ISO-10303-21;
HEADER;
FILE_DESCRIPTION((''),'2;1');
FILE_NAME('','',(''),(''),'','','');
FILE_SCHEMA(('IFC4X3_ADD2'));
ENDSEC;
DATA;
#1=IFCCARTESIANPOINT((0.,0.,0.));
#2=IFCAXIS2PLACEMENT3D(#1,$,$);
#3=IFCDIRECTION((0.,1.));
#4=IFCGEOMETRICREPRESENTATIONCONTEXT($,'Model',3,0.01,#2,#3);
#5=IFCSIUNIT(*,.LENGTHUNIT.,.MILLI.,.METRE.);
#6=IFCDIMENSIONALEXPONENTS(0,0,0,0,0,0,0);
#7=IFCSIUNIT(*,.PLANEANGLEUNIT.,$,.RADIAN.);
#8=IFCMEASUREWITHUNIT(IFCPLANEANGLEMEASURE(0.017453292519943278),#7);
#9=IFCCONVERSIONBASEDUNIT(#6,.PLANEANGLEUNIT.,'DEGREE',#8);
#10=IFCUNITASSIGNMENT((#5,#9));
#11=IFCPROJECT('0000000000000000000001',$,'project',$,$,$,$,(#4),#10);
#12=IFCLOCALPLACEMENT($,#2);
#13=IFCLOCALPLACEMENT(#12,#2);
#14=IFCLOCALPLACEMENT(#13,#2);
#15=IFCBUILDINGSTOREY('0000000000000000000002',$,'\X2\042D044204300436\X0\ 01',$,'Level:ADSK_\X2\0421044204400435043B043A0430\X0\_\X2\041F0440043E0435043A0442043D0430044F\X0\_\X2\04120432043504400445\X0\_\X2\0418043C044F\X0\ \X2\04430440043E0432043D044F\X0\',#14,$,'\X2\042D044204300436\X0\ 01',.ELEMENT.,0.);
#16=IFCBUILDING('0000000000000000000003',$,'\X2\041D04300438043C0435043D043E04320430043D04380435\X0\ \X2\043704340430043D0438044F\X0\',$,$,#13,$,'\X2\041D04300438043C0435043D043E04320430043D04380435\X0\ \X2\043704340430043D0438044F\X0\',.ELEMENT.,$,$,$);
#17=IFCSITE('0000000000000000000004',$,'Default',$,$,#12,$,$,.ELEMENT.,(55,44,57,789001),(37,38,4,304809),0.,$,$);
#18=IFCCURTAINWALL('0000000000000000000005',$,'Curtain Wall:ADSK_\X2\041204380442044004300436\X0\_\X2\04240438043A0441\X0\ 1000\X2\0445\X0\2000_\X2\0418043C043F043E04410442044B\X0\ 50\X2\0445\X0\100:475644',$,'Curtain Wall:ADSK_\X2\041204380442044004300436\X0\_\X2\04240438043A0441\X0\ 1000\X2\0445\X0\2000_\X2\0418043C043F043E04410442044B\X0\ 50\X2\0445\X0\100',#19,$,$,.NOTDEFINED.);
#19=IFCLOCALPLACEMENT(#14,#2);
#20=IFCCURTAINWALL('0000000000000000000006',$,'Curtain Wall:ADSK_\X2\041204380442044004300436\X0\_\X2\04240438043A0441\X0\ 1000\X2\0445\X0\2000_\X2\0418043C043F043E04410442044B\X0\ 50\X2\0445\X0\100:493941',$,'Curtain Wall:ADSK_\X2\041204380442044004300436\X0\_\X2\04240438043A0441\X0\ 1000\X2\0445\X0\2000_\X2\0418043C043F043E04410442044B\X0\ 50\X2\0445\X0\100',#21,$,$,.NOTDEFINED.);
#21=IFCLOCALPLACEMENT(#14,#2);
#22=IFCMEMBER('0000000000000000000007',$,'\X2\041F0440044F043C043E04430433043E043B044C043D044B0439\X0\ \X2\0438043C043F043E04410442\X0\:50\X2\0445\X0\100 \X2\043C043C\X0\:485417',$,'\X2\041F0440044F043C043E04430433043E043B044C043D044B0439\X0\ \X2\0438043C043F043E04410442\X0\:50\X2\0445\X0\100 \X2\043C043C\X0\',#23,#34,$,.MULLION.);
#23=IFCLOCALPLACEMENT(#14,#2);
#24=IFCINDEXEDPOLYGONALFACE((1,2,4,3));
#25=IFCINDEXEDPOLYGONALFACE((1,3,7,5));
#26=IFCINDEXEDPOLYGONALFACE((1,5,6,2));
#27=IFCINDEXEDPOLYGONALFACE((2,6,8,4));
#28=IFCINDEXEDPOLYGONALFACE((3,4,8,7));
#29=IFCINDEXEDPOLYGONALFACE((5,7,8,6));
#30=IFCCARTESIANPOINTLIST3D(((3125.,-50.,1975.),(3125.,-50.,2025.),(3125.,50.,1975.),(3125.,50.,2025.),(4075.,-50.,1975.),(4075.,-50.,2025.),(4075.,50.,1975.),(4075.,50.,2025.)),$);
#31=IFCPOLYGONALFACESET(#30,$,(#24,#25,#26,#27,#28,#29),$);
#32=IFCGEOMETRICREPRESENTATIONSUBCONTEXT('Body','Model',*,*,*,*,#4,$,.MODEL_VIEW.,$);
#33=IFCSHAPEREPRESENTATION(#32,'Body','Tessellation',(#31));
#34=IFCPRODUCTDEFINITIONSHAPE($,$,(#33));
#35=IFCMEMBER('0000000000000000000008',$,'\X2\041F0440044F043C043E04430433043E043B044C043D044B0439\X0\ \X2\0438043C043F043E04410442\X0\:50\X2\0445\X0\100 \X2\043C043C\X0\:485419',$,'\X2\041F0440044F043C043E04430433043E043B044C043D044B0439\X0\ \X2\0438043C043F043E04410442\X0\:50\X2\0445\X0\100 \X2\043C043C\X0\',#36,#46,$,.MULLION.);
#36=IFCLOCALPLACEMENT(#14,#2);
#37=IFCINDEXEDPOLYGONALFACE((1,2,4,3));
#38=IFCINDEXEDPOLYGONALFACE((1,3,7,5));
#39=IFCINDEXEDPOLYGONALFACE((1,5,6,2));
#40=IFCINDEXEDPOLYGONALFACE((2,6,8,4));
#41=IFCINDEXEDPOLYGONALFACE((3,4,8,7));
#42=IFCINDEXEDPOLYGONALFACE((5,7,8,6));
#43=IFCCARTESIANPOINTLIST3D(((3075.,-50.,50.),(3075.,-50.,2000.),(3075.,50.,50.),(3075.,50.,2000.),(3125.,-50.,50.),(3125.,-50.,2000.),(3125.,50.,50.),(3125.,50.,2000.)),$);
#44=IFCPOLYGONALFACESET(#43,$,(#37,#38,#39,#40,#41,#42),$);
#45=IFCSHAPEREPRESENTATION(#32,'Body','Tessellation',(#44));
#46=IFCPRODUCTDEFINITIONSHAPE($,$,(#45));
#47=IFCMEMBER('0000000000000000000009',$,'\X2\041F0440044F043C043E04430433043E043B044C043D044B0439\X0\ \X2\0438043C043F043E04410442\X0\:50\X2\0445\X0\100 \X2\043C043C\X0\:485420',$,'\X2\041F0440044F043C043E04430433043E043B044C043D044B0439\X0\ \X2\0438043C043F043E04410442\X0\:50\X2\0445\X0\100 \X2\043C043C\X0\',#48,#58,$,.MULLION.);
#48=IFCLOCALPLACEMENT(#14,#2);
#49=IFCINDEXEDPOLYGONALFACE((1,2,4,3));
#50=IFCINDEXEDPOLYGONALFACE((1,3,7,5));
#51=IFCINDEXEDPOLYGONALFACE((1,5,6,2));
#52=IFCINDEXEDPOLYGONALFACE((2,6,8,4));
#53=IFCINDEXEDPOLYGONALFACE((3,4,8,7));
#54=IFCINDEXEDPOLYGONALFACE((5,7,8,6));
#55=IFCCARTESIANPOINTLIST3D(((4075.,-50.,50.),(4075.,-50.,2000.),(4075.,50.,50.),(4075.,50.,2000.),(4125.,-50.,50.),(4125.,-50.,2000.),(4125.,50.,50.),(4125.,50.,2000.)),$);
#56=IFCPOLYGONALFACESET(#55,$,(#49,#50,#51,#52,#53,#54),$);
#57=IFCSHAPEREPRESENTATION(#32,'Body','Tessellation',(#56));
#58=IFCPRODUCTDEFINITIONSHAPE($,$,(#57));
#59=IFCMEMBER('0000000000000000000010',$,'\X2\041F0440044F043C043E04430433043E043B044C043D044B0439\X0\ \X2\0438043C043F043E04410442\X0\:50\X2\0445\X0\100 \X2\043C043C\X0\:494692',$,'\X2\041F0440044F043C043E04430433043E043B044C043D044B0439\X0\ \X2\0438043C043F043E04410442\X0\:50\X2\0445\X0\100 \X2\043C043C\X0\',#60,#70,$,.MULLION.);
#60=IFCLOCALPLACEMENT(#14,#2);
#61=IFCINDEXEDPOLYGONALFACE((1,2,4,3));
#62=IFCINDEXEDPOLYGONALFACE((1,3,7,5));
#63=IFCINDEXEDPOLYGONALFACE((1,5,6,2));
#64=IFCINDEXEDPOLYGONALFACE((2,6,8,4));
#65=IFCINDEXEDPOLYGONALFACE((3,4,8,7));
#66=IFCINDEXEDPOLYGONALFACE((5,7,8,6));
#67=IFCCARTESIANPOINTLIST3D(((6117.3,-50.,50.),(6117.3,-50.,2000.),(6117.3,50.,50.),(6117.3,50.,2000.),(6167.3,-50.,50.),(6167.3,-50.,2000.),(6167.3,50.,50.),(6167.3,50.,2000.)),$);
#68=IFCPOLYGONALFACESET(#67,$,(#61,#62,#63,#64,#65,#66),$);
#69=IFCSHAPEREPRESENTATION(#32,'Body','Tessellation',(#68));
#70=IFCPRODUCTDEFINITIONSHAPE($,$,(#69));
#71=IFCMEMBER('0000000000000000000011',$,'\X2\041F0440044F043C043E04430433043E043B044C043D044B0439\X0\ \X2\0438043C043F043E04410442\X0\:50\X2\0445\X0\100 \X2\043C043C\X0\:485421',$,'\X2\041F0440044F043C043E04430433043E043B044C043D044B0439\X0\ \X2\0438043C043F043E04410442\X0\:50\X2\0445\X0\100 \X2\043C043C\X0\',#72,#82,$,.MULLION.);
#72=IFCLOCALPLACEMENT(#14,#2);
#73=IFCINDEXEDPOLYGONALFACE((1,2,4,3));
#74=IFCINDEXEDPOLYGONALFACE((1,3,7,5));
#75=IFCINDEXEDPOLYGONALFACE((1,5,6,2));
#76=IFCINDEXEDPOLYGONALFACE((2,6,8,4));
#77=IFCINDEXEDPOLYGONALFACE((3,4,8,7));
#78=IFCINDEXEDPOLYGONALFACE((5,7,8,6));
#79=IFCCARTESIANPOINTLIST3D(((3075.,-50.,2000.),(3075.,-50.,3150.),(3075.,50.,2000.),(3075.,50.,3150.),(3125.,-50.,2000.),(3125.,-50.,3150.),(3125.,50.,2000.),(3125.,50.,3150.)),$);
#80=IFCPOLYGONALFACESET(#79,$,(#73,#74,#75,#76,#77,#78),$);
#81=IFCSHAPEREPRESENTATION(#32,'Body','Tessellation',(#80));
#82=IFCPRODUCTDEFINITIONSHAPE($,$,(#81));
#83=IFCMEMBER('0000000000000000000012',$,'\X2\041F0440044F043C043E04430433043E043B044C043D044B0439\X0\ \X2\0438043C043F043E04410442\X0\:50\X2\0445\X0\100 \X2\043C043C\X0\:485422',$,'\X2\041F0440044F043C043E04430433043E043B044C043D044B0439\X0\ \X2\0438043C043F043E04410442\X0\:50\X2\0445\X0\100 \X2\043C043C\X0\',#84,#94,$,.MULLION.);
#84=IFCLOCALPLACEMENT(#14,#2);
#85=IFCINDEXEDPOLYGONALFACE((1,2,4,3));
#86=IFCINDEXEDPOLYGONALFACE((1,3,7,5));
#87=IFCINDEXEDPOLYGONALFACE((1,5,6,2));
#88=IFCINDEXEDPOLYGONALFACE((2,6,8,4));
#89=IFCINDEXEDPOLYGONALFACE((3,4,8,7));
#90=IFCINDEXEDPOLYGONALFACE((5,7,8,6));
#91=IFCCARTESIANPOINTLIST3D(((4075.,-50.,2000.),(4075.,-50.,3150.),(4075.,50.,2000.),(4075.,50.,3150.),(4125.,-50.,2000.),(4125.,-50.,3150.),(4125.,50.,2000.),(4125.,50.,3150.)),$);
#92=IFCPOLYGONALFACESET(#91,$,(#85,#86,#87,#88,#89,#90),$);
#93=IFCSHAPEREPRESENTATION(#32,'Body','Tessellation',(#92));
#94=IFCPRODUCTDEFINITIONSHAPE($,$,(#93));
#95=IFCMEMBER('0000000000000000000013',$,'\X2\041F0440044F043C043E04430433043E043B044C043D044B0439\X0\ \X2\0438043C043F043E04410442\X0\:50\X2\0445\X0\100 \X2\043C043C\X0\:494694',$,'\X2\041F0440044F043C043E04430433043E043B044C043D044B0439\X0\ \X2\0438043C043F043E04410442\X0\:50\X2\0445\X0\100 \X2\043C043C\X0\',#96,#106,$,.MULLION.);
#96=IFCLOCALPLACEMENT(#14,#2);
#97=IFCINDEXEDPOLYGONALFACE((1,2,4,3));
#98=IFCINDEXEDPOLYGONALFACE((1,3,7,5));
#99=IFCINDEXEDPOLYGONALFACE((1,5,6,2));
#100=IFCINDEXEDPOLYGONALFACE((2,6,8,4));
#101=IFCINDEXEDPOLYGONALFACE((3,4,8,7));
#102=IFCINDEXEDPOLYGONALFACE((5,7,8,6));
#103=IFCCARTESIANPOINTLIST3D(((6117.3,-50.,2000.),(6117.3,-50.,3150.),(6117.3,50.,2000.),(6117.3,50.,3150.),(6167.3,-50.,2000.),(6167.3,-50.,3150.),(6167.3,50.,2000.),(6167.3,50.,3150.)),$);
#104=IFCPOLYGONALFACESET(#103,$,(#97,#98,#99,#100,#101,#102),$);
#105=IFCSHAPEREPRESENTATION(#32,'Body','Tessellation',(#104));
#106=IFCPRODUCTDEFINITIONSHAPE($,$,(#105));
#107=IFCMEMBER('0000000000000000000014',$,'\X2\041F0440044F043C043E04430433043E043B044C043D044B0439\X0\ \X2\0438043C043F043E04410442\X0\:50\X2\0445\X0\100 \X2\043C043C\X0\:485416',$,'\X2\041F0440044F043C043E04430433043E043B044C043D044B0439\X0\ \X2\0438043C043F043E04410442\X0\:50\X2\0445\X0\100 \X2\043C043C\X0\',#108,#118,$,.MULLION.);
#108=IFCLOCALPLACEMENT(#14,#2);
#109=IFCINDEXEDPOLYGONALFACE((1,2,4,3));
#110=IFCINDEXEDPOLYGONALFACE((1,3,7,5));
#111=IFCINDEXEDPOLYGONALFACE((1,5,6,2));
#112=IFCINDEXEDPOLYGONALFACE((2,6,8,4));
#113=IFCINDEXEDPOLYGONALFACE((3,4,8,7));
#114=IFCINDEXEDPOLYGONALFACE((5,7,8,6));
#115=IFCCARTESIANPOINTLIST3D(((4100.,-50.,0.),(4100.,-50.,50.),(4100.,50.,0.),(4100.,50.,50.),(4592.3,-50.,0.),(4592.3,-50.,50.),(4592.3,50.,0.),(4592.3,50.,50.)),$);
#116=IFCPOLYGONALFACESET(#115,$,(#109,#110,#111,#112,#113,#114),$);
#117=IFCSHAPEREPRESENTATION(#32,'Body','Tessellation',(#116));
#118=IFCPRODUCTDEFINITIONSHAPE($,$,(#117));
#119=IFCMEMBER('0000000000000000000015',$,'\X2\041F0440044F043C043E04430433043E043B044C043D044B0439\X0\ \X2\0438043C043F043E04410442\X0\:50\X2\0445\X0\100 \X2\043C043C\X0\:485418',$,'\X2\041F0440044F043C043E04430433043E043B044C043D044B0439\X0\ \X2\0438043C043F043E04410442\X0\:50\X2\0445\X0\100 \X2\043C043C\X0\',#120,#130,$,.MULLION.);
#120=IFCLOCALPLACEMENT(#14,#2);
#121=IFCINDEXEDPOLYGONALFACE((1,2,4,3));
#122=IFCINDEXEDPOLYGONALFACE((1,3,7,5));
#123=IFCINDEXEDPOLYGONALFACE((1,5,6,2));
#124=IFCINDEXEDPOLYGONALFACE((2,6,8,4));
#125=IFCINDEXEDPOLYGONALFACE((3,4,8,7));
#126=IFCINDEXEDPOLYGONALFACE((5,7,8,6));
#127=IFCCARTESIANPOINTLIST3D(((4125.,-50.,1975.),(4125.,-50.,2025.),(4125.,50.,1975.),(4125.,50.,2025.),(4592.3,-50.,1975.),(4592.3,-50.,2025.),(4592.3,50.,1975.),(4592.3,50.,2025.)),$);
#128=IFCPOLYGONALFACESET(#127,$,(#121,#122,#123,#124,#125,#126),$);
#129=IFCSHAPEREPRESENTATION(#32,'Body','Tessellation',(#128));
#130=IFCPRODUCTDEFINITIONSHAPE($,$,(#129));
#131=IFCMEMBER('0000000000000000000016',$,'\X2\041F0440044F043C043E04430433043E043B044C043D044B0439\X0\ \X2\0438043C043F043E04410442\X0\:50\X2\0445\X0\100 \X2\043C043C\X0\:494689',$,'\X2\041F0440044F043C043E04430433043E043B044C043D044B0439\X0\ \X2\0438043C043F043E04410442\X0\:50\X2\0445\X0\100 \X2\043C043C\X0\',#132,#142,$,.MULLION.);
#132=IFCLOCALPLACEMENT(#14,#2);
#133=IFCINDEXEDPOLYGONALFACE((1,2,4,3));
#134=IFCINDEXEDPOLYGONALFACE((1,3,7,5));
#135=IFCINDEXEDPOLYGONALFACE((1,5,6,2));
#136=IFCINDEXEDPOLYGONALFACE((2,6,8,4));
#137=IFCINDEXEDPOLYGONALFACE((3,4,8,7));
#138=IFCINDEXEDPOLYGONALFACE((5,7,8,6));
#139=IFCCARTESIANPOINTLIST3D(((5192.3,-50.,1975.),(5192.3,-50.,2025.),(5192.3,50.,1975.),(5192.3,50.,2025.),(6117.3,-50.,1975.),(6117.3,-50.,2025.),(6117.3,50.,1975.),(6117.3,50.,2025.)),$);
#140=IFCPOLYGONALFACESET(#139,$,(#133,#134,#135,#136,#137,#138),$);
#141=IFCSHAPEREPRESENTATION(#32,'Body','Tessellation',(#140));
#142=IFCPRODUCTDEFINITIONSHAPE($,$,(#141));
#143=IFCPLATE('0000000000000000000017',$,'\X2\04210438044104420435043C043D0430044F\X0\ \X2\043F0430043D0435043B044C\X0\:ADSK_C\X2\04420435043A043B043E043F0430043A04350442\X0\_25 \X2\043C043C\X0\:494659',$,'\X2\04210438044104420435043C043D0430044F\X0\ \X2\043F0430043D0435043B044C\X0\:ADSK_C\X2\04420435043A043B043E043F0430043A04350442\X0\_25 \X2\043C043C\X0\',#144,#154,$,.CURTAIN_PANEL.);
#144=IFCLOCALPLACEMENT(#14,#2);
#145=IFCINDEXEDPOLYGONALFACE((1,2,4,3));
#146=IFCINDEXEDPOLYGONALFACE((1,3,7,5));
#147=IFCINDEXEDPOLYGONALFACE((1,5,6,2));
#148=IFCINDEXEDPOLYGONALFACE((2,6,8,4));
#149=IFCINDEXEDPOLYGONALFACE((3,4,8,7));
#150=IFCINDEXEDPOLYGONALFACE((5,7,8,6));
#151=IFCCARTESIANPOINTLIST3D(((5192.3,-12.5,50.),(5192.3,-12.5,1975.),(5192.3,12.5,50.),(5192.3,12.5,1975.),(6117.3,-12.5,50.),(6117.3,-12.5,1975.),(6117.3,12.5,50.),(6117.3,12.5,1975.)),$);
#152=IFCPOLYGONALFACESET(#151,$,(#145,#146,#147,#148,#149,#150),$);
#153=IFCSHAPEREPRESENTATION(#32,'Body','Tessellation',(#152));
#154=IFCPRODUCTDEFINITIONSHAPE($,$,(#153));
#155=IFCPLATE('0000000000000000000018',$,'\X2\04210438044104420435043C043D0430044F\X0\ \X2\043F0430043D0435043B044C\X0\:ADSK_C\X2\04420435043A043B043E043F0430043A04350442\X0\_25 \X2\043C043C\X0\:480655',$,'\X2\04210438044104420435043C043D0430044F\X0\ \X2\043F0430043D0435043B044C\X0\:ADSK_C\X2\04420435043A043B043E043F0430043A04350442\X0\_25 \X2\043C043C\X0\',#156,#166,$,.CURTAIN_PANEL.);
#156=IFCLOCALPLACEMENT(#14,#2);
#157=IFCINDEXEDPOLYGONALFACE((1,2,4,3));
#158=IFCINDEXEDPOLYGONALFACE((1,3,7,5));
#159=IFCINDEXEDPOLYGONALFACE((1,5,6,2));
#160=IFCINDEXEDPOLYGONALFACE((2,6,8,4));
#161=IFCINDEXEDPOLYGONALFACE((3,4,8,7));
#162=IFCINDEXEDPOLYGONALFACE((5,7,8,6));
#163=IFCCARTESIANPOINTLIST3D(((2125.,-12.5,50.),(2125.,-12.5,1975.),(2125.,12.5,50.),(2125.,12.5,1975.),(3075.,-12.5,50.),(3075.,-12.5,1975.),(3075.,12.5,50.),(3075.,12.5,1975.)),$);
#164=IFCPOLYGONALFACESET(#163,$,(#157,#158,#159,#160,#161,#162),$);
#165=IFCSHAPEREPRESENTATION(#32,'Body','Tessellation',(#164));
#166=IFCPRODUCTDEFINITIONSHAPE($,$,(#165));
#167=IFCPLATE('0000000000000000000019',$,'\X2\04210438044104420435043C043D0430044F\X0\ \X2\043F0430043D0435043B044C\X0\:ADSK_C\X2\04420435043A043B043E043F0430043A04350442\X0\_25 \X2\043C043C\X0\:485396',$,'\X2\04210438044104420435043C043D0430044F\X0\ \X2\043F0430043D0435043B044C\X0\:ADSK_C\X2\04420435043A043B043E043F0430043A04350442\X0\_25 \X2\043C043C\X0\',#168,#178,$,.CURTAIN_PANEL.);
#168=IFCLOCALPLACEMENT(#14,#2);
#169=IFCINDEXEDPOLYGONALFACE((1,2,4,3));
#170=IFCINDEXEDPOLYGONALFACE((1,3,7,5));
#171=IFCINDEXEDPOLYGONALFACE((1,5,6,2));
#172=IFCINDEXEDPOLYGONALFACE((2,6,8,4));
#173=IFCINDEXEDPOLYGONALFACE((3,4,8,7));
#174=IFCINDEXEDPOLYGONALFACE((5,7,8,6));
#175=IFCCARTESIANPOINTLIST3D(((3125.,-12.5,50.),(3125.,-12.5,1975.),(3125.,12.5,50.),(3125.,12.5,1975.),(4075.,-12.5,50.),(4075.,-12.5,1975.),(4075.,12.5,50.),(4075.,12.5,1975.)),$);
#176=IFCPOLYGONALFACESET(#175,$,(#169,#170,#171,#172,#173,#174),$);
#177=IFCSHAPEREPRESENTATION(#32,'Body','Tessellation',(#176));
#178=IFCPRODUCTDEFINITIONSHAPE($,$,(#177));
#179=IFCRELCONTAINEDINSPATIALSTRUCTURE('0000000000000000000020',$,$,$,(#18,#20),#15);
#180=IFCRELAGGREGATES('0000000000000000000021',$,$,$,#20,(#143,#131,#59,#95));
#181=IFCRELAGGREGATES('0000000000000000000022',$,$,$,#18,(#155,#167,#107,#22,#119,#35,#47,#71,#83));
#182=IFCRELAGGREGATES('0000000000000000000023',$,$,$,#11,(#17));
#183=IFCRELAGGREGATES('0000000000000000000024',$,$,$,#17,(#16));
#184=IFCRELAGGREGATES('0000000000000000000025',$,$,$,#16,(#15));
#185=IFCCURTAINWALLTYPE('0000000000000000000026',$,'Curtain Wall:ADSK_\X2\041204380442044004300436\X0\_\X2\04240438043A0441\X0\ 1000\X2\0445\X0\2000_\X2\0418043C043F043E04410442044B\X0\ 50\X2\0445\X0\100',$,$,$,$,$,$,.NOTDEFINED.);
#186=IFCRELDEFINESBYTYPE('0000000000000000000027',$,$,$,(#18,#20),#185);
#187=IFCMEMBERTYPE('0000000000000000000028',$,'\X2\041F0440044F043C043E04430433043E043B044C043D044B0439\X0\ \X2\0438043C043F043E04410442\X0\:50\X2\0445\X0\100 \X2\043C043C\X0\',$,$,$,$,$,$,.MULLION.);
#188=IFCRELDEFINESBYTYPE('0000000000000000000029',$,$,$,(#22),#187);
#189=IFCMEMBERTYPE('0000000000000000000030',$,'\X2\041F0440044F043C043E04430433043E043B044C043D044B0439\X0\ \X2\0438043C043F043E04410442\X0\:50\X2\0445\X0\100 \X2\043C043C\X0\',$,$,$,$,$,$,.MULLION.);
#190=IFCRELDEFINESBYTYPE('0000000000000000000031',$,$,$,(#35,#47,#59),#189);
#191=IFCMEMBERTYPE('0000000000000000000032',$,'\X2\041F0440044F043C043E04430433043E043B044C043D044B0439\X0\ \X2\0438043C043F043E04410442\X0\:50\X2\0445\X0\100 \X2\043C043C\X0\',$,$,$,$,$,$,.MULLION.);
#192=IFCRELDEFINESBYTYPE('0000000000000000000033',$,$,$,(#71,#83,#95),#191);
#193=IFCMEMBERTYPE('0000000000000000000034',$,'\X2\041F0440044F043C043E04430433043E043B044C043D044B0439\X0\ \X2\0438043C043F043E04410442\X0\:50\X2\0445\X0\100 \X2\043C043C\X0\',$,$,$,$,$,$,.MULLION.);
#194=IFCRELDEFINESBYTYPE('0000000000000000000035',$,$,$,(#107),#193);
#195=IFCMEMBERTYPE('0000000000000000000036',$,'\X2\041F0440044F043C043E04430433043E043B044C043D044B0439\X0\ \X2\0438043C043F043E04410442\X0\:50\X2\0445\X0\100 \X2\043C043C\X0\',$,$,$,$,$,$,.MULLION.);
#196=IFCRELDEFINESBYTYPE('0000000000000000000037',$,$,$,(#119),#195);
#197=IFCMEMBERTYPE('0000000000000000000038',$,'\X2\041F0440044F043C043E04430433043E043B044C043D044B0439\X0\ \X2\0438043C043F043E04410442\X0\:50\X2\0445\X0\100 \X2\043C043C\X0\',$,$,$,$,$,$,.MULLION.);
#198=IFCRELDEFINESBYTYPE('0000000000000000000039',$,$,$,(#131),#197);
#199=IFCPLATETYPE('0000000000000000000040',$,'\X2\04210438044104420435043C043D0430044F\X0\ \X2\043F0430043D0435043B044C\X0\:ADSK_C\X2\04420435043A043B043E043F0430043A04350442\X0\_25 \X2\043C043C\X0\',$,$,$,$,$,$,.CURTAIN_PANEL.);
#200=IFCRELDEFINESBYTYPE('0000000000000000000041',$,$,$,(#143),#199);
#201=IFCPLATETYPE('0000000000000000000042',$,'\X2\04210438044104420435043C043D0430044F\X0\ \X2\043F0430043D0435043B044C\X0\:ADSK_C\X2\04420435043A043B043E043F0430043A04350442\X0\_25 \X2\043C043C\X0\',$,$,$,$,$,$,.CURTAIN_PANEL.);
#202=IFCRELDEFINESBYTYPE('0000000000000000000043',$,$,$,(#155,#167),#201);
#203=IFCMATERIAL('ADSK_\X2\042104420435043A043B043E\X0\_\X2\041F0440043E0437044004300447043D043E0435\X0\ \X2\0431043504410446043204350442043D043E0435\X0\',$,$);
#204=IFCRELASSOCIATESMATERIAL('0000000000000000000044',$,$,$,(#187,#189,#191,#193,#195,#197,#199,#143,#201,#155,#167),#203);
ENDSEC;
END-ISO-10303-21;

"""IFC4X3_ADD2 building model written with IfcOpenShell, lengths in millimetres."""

from ifc_helpers import new_model, entity, si_unit, converted_unit, direction, frame, frame_2d, origin, origin_2d_with_axis, place, context, subcontext, project, spatial, rectangle, extrude, source, transform, mapped, material, material_profile, profile_set, type_object, type_shapes, element, aggregate, save


model = new_model("IFC4X3_ADD2")

# Units and contexts
model_context = context("Model", 3, precision=0.01, world=origin(), true_north=direction((0.0, 1.0)))
body_context = subcontext(model_context, "Body", "Model", "MODEL_VIEW")
ifc_project = project(units=[si_unit("LENGTHUNIT", "METRE", prefix="MILLI"), converted_unit("PLANEANGLEUNIT", "DEGREE", entity("IfcPlaneAngleMeasure", 0.017453292519943278), si_unit("PLANEANGLEUNIT", "RADIAN"), dimensions=[0, 0, 0, 0, 0, 0, 0])], contexts=[model_context])

# Site, building, storey
site_placement = place(None, origin())
site = spatial("IfcSite", under=ifc_project, at=site_placement, Name="Default", CompositionType="ELEMENT", RefLatitude=(55, 44, 57, 789001), RefLongitude=(37, 38, 4, 304809), RefElevation=0.0)
building_placement = place(site_placement, origin())
building = spatial("IfcBuilding", under=site, at=building_placement, Name="Наименование здания", LongName="Наименование здания", CompositionType="ELEMENT")
storey_placement = place(building_placement, origin())
storey = spatial("IfcBuildingStorey", under=building, at=storey_placement, Name="Этаж 01", ObjectType="Level:ADSK_Стрелка_Проектная_Вверх_Имя уровня", LongName="Этаж 01", CompositionType="ELEMENT", Elevation=0.0)

# Curtain walls
curtain_wall_type = type_object("IfcCurtainWallType", Name="Curtain Wall:ADSK_Витраж_Фикс 1000х2000_Импосты 50х100", PredefinedType="NOTDEFINED")
curtain_wall_1_placement = place(storey_placement, origin())
curtain_wall_1 = element("IfcCurtainWall", 1, at=curtain_wall_1_placement, inside=storey, type_object=curtain_wall_type, Name="Curtain Wall:ADSK_Витраж_Фикс 1000х2000_Импосты 50х100:475644", ObjectType="Curtain Wall:ADSK_Витраж_Фикс 1000х2000_Импосты 50х100", PredefinedType="NOTDEFINED")
ifc_material_1 = material(Name="ADSK_Стекло_Прозрачное бесцветное")
ifc_material_profile = material_profile(ifc_material_1, rectangle(XDim=50.0, YDim=100.0, at=frame_2d((0.0, 0.0), x_axis=(1.0, 0.0))), Name="50х100 мм")
ifc_profile_set = profile_set([ifc_material_profile], Name="50х100 мм")
curtain_wall_2_placement = place(storey_placement, origin())
curtain_wall_2 = element("IfcCurtainWall", 2, at=curtain_wall_2_placement, inside=storey, type_object=curtain_wall_type, Name="Curtain Wall:ADSK_Витраж_Фикс 1000х2000_Импосты 50х100:493941", ObjectType="Curtain Wall:ADSK_Витраж_Фикс 1000х2000_Импосты 50х100", PredefinedType="NOTDEFINED")

# Members
member_type_1 = type_object("IfcMemberType", Name="Прямоугольный импост:50х100 мм", PredefinedType="MULLION", material=ifc_profile_set)
shared_shape_1 = source(origin(), body_context, "Body", "SweptSolid", [
    extrude(rectangle(XDim=50.0, YDim=100.0, at=frame_2d((0.0, 0.0), x_axis=(1.0, 0.0))), frame((0.0, 0.0, -950.0), z_axis=(0.0, 0.0, 1.0), x_axis=(-1.0, 0.0, 0.0)), (0.0, 0.0, 1.0), 950.0),
])
type_shapes(member_type_1, [shared_shape_1])
member_1_placement = place(curtain_wall_1_placement, frame((4075.0, 0.0, 2000.0), z_axis=(1.0, 0.0, 0.0), x_axis=(0.0, 0.0, 1.0)))
member_1 = element("IfcMember", 3, at=member_1_placement, type_object=member_type_1, Name="Прямоугольный импост:50х100 мм:485417", ObjectType="Прямоугольный импост:50х100 мм", PredefinedType="MULLION", context=body_context, shape_type="MappedRepresentation", body=[
    mapped(shared_shape_1, transform((0.0, 0.0, 0.0), scale=1.0)),
])
member_type_2 = type_object("IfcMemberType", Name="Прямоугольный импост:50х100 мм", PredefinedType="MULLION", material=ifc_profile_set)
shared_shape_2 = source(origin(), body_context, "Body", "SweptSolid", [
    extrude(rectangle(XDim=50.0, YDim=100.0, at=frame_2d((0.0, 0.0), x_axis=(1.0, 0.0))), frame((0.0, 0.0, -1950.0), z_axis=(0.0, 0.0, 1.0), x_axis=(-1.0, 0.0, 0.0)), (0.0, 0.0, 1.0), 1950.0),
])
type_shapes(member_type_2, [shared_shape_2])
member_2_placement = place(curtain_wall_1_placement, frame((3100.0, 0.0, 50.0), z_axis=(0.0, 0.0, -1.0), x_axis=(1.0, 0.0, 0.0)))
member_2 = element("IfcMember", 4, at=member_2_placement, type_object=member_type_2, Name="Прямоугольный импост:50х100 мм:485419", ObjectType="Прямоугольный импост:50х100 мм", PredefinedType="MULLION", context=body_context, shape_type="MappedRepresentation", body=[
    mapped(shared_shape_2, transform((0.0, 0.0, 0.0), scale=1.0)),
])
member_3_placement = place(curtain_wall_1_placement, frame((4100.0, 0.0, 50.0), z_axis=(0.0, 0.0, -1.0), x_axis=(1.0, 0.0, 0.0)))
member_3 = element("IfcMember", 5, at=member_3_placement, type_object=member_type_2, Name="Прямоугольный импост:50х100 мм:485420", ObjectType="Прямоугольный импост:50х100 мм", PredefinedType="MULLION", context=body_context, shape_type="MappedRepresentation", body=[
    mapped(shared_shape_2, transform((0.0, 0.0, 0.0), scale=1.0)),
])
member_4_placement = place(curtain_wall_2_placement, frame((6142.3, 0.0, 50.0), z_axis=(0.0, 0.0, -1.0), x_axis=(1.0, 0.0, 0.0)))
member_4 = element("IfcMember", 6, at=member_4_placement, type_object=member_type_2, Name="Прямоугольный импост:50х100 мм:494692", ObjectType="Прямоугольный импост:50х100 мм", PredefinedType="MULLION", context=body_context, shape_type="MappedRepresentation", body=[
    mapped(shared_shape_2, transform((0.0, 0.0, 0.0), scale=1.0)),
])
member_type_3 = type_object("IfcMemberType", Name="Прямоугольный импост:50х100 мм", PredefinedType="MULLION", material=ifc_profile_set)
shared_shape_3 = source(origin(), body_context, "Body", "SweptSolid", [
    extrude(rectangle(XDim=50.0, YDim=100.0, at=frame_2d((0.0, 0.0), x_axis=(1.0, 0.0))), frame((0.0, 0.0, -1150.0), z_axis=(0.0, 0.0, 1.0), x_axis=(-1.0, 0.0, 0.0)), (0.0, 0.0, 1.0), 1150.0),
])
type_shapes(member_type_3, [shared_shape_3])
member_5_placement = place(curtain_wall_1_placement, frame((3100.0, 0.0, 2000.0), z_axis=(0.0, 0.0, -1.0), x_axis=(1.0, 0.0, 0.0)))
member_5 = element("IfcMember", 7, at=member_5_placement, type_object=member_type_3, Name="Прямоугольный импост:50х100 мм:485421", ObjectType="Прямоугольный импост:50х100 мм", PredefinedType="MULLION", context=body_context, shape_type="MappedRepresentation", body=[
    mapped(shared_shape_3, transform((0.0, 0.0, 0.0), scale=1.0)),
])
member_6_placement = place(curtain_wall_1_placement, frame((4100.0, 0.0, 2000.0), z_axis=(0.0, 0.0, -1.0), x_axis=(1.0, 0.0, 0.0)))
member_6 = element("IfcMember", 8, at=member_6_placement, type_object=member_type_3, Name="Прямоугольный импост:50х100 мм:485422", ObjectType="Прямоугольный импост:50х100 мм", PredefinedType="MULLION", context=body_context, shape_type="MappedRepresentation", body=[
    mapped(shared_shape_3, transform((0.0, 0.0, 0.0), scale=1.0)),
])
member_7_placement = place(curtain_wall_2_placement, frame((6142.3, 0.0, 2000.0), z_axis=(0.0, 0.0, -1.0), x_axis=(1.0, 0.0, 0.0)))
member_7 = element("IfcMember", 9, at=member_7_placement, type_object=member_type_3, Name="Прямоугольный импост:50х100 мм:494694", ObjectType="Прямоугольный импост:50х100 мм", PredefinedType="MULLION", context=body_context, shape_type="MappedRepresentation", body=[
    mapped(shared_shape_3, transform((0.0, 0.0, 0.0), scale=1.0)),
])
member_type_4 = type_object("IfcMemberType", Name="Прямоугольный импост:50х100 мм", PredefinedType="MULLION", material=ifc_profile_set)
shared_shape_4 = source(origin(), body_context, "Body", "SweptSolid", [
    extrude(rectangle(XDim=50.0, YDim=100.0, at=frame_2d((0.0, 0.0), x_axis=(1.0, 0.0))), frame((-25.0, 0.0, -492.3), z_axis=(0.0, 0.0, 1.0), x_axis=(-1.0, 0.0, 0.0)), (0.0, 0.0, 1.0), 492.3),
])
type_shapes(member_type_4, [shared_shape_4])
member_8_placement = place(curtain_wall_1_placement, frame((4100.0, 0.0, 0.0), z_axis=(-1.0, 0.0, 0.0), x_axis=(0.0, 0.0, -1.0)))
member_8 = element("IfcMember", 10, at=member_8_placement, type_object=member_type_4, Name="Прямоугольный импост:50х100 мм:485416", ObjectType="Прямоугольный импост:50х100 мм", PredefinedType="MULLION", context=body_context, shape_type="MappedRepresentation", body=[
    mapped(shared_shape_4, transform((0.0, 0.0, 0.0), scale=1.0)),
])
member_type_5 = type_object("IfcMemberType", Name="Прямоугольный импост:50х100 мм", PredefinedType="MULLION", material=ifc_profile_set)
shared_shape_5 = source(origin(), body_context, "Body", "SweptSolid", [
    extrude(rectangle(XDim=50.0, YDim=100.0, at=frame_2d((0.0, 0.0), x_axis=(1.0, 0.0))), frame((0.0, 0.0, -467.3), z_axis=(0.0, 0.0, 1.0), x_axis=(-1.0, 0.0, 0.0)), (0.0, 0.0, 1.0), 467.3),
])
type_shapes(member_type_5, [shared_shape_5])
member_9_placement = place(curtain_wall_1_placement, frame((4592.3, 0.0, 2000.0), z_axis=(1.0, 0.0, 0.0), x_axis=(0.0, 0.0, 1.0)))
member_9 = element("IfcMember", 11, at=member_9_placement, type_object=member_type_5, Name="Прямоугольный импост:50х100 мм:485418", ObjectType="Прямоугольный импост:50х100 мм", PredefinedType="MULLION", context=body_context, shape_type="MappedRepresentation", body=[
    mapped(shared_shape_5, transform((0.0, 0.0, 0.0), scale=1.0)),
])
member_type_6 = type_object("IfcMemberType", Name="Прямоугольный импост:50х100 мм", PredefinedType="MULLION", material=ifc_profile_set)
shared_shape_6 = source(origin(), body_context, "Body", "SweptSolid", [
    extrude(rectangle(XDim=50.0, YDim=100.0, at=frame_2d((0.0, 0.0), x_axis=(1.0, 0.0))), frame((0.0, 0.0, -925.0), z_axis=(0.0, 0.0, 1.0), x_axis=(-1.0, 0.0, 0.0)), (0.0, 0.0, 1.0), 925.0),
])
type_shapes(member_type_6, [shared_shape_6])
member_10_placement = place(curtain_wall_2_placement, frame((6117.3, 0.0, 2000.0), z_axis=(1.0, 0.0, 0.0), x_axis=(0.0, 0.0, 1.0)))
member_10 = element("IfcMember", 12, at=member_10_placement, type_object=member_type_6, Name="Прямоугольный импост:50х100 мм:494689", ObjectType="Прямоугольный импост:50х100 мм", PredefinedType="MULLION", context=body_context, shape_type="MappedRepresentation", body=[
    mapped(shared_shape_6, transform((0.0, 0.0, 0.0), scale=1.0)),
])

# Plates
plate_type_1 = type_object("IfcPlateType", Name="Системная панель:ADSK_Cтеклопакет_25 мм", PredefinedType="CURTAIN_PANEL", material=ifc_material_1)
shared_shape_7 = source(origin(), body_context, "Body", "SweptSolid", [
    extrude(rectangle(XDim=25.0, YDim=925.0, at=origin_2d_with_axis()), frame((0.0, 0.0, 0.0), z_axis=(0.0, 0.0, 1.0), x_axis=(0.0, 1.0, 0.0)), (0.0, 0.0, 1.0), 1925.0),
])
type_shapes(plate_type_1, [shared_shape_7])
plate_1_placement = place(curtain_wall_2_placement, frame((5654.8, 0.0, 50.0)))
plate_1 = element("IfcPlate", 13, at=plate_1_placement, type_object=plate_type_1, material=ifc_material_1, Name="Системная панель:ADSK_Cтеклопакет_25 мм:494659", ObjectType="Системная панель:ADSK_Cтеклопакет_25 мм", PredefinedType="CURTAIN_PANEL", context=body_context, shape_type="MappedRepresentation", body=[
    mapped(shared_shape_7, transform((0.0, 0.0, 0.0), scale=1.0)),
])
plate_type_2 = type_object("IfcPlateType", Name="Системная панель:ADSK_Cтеклопакет_25 мм", PredefinedType="CURTAIN_PANEL", material=ifc_material_1)
shared_shape_8 = source(origin(), body_context, "Body", "SweptSolid", [
    extrude(rectangle(XDim=25.0, YDim=950.0, at=origin_2d_with_axis()), frame((0.0, 0.0, 0.0), z_axis=(0.0, 0.0, 1.0), x_axis=(0.0, 1.0, 0.0)), (0.0, 0.0, 1.0), 1925.0),
])
type_shapes(plate_type_2, [shared_shape_8])
plate_2_placement = place(curtain_wall_1_placement, frame((2600.0, 0.0, 50.0)))
plate_2 = element("IfcPlate", 14, at=plate_2_placement, type_object=plate_type_2, material=ifc_material_1, Name="Системная панель:ADSK_Cтеклопакет_25 мм:480655", ObjectType="Системная панель:ADSK_Cтеклопакет_25 мм", PredefinedType="CURTAIN_PANEL", context=body_context, shape_type="MappedRepresentation", body=[
    mapped(shared_shape_8, transform((0.0, 0.0, 0.0), scale=1.0)),
])
plate_3_placement = place(curtain_wall_1_placement, frame((3600.0, 0.0, 50.0)))
plate_3 = element("IfcPlate", 15, at=plate_3_placement, type_object=plate_type_2, material=ifc_material_1, Name="Системная панель:ADSK_Cтеклопакет_25 мм:485396", ObjectType="Системная панель:ADSK_Cтеклопакет_25 мм", PredefinedType="CURTAIN_PANEL", context=body_context, shape_type="MappedRepresentation", body=[
    mapped(shared_shape_8, transform((0.0, 0.0, 0.0), scale=1.0)),
])
aggregate(curtain_wall_2, [plate_1, member_10, member_4, member_7])
aggregate(curtain_wall_1, [plate_2, plate_3, member_8, member_1, member_9, member_2, member_3, member_5, member_6])

save(model, "model.ifc")
